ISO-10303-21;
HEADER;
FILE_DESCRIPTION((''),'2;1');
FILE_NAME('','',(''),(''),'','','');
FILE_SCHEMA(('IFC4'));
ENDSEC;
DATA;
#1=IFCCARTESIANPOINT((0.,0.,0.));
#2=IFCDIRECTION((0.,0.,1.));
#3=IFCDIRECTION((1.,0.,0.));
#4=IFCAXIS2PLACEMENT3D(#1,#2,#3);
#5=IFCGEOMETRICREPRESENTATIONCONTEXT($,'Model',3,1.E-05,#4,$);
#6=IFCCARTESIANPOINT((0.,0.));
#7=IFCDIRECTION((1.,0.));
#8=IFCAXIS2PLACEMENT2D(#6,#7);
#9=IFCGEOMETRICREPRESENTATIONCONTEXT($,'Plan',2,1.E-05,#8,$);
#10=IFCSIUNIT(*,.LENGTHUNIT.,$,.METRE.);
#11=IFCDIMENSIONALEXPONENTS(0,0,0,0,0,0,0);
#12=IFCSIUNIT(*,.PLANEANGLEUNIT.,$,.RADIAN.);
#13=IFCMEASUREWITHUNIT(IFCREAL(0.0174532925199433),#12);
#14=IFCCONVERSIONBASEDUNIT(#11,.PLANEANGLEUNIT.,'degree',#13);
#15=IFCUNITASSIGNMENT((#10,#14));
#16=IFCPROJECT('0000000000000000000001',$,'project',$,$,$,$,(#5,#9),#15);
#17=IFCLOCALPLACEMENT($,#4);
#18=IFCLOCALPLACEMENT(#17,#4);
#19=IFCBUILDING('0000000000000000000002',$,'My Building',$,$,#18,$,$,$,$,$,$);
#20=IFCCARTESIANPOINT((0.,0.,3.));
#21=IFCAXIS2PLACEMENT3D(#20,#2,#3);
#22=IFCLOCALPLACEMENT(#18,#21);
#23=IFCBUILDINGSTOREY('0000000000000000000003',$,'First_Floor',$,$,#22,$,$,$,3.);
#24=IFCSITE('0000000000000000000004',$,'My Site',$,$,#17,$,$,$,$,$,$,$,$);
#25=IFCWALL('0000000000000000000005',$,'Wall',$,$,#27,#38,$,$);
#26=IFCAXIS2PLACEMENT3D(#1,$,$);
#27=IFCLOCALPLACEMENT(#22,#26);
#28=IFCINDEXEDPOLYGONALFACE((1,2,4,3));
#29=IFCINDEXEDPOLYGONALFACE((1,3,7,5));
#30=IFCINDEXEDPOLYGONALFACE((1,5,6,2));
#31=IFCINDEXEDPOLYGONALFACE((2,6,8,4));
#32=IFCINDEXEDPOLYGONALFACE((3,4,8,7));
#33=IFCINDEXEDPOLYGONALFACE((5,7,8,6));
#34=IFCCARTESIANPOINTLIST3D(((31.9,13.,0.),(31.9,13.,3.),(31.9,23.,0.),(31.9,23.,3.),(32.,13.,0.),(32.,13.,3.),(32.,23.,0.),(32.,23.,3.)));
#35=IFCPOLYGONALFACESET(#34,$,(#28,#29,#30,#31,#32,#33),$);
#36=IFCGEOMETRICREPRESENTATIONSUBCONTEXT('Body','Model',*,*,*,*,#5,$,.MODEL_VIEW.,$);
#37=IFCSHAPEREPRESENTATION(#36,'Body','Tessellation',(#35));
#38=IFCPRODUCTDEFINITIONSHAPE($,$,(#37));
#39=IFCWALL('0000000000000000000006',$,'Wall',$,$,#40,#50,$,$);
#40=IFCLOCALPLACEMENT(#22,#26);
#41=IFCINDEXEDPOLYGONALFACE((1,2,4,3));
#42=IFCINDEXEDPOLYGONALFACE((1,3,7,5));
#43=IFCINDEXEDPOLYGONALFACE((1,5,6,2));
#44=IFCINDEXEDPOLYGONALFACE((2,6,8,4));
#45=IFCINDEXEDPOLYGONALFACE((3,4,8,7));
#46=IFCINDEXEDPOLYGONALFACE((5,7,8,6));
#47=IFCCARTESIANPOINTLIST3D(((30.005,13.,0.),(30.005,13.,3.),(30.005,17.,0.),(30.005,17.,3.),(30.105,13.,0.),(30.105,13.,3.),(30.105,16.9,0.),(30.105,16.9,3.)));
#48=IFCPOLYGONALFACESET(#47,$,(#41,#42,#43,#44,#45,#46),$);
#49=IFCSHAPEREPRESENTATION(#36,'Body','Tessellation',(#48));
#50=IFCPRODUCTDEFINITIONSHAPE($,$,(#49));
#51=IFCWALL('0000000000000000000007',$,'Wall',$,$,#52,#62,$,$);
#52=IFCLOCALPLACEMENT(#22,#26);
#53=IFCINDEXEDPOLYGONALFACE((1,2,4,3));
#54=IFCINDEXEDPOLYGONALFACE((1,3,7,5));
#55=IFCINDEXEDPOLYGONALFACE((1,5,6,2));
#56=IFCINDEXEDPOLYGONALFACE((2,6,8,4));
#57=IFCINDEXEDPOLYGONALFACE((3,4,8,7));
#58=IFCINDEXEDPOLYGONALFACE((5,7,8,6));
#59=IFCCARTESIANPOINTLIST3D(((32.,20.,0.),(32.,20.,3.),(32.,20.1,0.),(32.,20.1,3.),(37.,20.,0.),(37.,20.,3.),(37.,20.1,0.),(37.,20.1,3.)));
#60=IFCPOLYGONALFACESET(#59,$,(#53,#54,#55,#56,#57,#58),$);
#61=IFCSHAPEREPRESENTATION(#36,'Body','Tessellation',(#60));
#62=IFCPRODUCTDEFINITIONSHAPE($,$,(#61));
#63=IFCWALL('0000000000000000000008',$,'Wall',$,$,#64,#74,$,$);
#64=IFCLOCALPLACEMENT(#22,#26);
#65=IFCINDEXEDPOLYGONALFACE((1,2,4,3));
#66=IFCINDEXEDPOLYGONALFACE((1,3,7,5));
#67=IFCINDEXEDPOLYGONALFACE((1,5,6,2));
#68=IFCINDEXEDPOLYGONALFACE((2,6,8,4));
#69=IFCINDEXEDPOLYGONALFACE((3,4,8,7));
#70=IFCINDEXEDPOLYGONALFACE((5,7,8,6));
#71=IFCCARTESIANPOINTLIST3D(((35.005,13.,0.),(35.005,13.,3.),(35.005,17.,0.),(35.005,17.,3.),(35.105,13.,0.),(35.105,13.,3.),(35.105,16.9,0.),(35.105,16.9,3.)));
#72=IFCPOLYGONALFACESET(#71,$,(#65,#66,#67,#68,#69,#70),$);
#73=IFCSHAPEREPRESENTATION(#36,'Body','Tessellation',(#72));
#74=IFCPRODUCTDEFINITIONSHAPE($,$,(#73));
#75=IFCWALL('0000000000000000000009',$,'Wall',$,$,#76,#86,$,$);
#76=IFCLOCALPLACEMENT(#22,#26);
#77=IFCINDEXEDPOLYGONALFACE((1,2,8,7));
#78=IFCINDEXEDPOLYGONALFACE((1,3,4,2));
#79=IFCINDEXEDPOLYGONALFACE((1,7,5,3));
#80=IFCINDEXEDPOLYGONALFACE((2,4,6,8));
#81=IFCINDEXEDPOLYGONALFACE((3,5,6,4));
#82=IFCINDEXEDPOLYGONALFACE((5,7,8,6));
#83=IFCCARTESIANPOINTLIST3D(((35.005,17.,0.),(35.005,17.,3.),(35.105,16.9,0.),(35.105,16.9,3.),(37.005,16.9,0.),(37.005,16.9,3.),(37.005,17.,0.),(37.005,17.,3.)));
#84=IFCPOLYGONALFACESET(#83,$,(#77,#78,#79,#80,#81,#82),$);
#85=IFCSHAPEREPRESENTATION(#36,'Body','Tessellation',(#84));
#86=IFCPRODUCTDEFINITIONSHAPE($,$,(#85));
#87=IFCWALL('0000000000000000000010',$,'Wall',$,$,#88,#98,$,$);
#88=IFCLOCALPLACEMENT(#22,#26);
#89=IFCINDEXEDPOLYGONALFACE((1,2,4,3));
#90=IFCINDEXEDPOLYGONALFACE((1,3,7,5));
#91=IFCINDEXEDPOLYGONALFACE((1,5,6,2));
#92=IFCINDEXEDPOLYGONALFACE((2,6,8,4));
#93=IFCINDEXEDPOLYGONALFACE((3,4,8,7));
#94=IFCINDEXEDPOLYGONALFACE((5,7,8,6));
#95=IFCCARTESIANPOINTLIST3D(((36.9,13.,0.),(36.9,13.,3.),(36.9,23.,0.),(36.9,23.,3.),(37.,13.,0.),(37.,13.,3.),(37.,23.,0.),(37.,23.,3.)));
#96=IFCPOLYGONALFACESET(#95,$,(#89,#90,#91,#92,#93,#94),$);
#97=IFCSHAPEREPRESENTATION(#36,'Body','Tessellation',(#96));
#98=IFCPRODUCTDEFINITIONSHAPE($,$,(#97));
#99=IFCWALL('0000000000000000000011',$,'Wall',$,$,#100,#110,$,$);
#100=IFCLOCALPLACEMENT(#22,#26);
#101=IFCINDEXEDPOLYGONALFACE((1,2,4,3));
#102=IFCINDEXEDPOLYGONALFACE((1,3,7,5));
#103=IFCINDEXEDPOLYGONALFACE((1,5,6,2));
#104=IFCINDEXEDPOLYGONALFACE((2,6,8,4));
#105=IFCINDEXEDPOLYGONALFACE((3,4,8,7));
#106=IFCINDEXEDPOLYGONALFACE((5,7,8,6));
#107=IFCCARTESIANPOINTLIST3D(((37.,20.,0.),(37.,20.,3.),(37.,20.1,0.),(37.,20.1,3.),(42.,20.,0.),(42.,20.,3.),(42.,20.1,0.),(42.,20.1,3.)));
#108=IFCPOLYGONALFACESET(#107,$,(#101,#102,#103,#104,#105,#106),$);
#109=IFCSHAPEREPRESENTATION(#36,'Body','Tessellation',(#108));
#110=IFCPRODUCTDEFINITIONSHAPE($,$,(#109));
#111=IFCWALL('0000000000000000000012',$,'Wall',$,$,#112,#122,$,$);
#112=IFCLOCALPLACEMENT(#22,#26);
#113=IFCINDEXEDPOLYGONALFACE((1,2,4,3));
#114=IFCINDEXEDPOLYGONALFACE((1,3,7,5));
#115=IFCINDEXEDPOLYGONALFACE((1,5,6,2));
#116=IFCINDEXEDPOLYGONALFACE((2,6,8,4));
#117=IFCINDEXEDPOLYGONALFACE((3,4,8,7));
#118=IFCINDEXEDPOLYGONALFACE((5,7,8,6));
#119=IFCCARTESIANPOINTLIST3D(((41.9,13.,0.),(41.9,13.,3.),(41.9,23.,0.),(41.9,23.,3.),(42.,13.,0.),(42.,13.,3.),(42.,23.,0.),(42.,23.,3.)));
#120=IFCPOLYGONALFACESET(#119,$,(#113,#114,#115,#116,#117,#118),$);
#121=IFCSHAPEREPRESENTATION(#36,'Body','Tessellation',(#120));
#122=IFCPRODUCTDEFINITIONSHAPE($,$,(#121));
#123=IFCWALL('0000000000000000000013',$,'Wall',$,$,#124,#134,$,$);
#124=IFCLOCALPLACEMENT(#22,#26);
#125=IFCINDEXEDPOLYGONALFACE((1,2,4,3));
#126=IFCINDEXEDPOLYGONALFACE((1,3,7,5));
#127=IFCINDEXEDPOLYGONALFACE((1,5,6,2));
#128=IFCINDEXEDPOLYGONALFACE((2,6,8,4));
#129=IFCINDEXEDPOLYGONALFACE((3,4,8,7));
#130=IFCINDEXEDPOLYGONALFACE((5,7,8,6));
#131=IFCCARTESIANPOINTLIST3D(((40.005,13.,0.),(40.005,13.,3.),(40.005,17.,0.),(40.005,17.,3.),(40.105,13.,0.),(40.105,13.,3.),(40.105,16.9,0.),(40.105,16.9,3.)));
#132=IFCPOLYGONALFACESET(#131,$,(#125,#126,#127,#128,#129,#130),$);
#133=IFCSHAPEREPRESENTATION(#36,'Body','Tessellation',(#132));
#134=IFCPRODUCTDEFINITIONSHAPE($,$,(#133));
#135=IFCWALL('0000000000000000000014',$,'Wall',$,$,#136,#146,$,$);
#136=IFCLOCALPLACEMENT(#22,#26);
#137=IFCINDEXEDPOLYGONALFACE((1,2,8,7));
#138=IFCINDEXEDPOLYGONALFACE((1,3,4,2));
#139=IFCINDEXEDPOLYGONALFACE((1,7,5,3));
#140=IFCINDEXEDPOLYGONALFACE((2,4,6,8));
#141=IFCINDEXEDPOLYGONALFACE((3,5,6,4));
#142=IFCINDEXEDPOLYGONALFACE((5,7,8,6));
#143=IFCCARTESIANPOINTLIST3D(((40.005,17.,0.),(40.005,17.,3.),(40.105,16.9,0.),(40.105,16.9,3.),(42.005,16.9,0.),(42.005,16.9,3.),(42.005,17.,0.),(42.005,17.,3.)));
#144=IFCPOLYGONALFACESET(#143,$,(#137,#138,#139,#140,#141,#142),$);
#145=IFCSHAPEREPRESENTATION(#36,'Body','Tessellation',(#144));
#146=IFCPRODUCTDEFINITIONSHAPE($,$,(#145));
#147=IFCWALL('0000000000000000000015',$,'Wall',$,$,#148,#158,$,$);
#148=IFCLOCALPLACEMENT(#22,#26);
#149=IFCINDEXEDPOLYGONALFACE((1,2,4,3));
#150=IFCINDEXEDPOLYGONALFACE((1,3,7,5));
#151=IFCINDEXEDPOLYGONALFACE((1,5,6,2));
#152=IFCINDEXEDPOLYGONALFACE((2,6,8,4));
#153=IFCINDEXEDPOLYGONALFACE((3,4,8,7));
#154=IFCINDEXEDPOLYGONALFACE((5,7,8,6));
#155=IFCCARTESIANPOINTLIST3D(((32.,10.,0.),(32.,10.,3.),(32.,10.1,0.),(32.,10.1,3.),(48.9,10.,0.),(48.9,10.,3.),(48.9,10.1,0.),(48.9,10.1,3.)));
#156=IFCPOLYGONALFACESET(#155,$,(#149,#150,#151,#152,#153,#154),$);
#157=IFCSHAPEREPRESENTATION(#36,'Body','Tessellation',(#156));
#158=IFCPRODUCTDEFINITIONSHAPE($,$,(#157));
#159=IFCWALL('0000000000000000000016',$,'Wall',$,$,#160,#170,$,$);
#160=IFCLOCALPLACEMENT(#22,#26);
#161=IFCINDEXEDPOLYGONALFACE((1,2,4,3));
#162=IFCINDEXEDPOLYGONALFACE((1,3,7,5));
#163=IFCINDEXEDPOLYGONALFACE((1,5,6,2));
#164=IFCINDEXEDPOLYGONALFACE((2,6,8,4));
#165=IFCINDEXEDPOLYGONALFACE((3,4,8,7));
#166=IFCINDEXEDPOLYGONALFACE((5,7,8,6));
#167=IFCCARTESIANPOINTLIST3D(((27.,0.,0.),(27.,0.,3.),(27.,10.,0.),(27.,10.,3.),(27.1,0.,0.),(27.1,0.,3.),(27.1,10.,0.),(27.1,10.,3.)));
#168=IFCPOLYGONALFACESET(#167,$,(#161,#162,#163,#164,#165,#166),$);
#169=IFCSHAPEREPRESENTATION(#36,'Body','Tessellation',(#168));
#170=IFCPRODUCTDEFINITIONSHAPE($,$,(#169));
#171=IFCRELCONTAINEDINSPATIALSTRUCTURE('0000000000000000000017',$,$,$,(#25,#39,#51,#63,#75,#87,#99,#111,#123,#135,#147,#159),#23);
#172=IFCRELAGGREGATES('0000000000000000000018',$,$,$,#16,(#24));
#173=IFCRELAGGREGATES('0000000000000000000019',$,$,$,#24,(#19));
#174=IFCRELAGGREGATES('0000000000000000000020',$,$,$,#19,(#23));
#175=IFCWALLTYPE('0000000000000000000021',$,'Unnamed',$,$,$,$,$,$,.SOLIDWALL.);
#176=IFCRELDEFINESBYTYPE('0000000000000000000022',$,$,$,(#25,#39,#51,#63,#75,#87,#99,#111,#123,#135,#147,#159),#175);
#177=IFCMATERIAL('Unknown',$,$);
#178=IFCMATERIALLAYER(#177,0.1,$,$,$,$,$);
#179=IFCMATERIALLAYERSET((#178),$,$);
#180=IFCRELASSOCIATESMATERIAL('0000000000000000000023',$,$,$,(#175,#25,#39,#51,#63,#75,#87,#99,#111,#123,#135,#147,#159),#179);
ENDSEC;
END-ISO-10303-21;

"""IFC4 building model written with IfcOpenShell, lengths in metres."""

from ifc_helpers import new_model, entity, si_unit, converted_unit, frame, origin_with_axes, origin_2d_with_axis, place, context, subcontext, project, spatial, line, indexed_curve, outline, extrude, material, layer, layer_set, layer_usage, type_object, element, save


model = new_model("IFC4")

# Units and contexts
model_context = context("Model", 3, precision=1e-05, world=origin_with_axes())
plan_context = context("Plan", 2, precision=1e-05, world=origin_2d_with_axis())
body_context = subcontext(model_context, "Body", "Model", "MODEL_VIEW")
ifc_project = project(units=[si_unit("LENGTHUNIT", "METRE"), converted_unit("PLANEANGLEUNIT", "degree", entity("IfcReal", 0.0174532925199433), si_unit("PLANEANGLEUNIT", "RADIAN"), dimensions=[0, 0, 0, 0, 0, 0, 0])], contexts=[model_context, plan_context])

# Site, building, storey
site_placement = place(None, origin_with_axes())
site = spatial("IfcSite", under=ifc_project, at=site_placement, Name="My Site")
building_placement = place(site_placement, origin_with_axes())
building = spatial("IfcBuilding", under=site, at=building_placement, Name="My Building")
storey_placement = place(building_placement, frame((0.0, 0.0, 3.0), z_axis=(0.0, 0.0, 1.0), x_axis=(1.0, 0.0, 0.0)))
storey = spatial("IfcBuildingStorey", under=building, at=storey_placement, Name="First_Floor", Elevation=3.0)

# Shared definitions
ifc_material = material(Name="Unknown")

# Walls
ifc_layer_1 = layer(ifc_material, 0.1)
ifc_layer_set_1 = layer_set([ifc_layer_1])
wall_type = type_object("IfcWallType", Name="Unnamed", PredefinedType="SOLIDWALL", material=ifc_layer_set_1)
ifc_layer_usage_1 = layer_usage(ifc_layer_set_1, "AXIS2", "POSITIVE", 0.0)
wall_1_placement = place(storey_placement, frame((31.9, 23.0, 0.0), z_axis=(0.0, 0.0, 1.0), x_axis=(0.0, -1.0, 0.0)))
element("IfcWall", 1, at=wall_1_placement, inside=storey, type_object=wall_type, material=ifc_layer_usage_1, Name="Wall", context=body_context, shape_type="SweptSolid", body=[
    extrude(outline(indexed_curve([(0.0, 0.0), (0.0, 0.1), (10.0, 0.1), (10.0, 0.0)], segments=[line(1, 2, 3, 4, 1)])), origin_with_axes(), (0.0, 0.0, 1.0), 3.0),
])
ifc_layer_usage_2 = layer_usage(ifc_layer_set_1, "AXIS2", "POSITIVE", 0.0)
wall_2_placement = place(storey_placement, frame((30.005, 17.0, 0.0), z_axis=(0.0, 0.0, 1.0), x_axis=(0.0, -1.0, 0.0)))
element("IfcWall", 2, at=wall_2_placement, inside=storey, type_object=wall_type, material=ifc_layer_usage_2, Name="Wall", context=body_context, shape_type="SweptSolid", body=[
    extrude(outline(indexed_curve([(0.0, 0.0), (0.1, 0.1), (4.0, 0.1), (4.0, 0.0)], segments=[line(1, 2, 3, 4, 1)])), origin_with_axes(), (0.0, 0.0, 1.0), 3.0),
])
ifc_layer_usage_3 = layer_usage(ifc_layer_set_1, "AXIS2", "POSITIVE", 0.0)
wall_3_placement = place(storey_placement, frame((32.0, 20.0, 0.0), z_axis=(0.0, 0.0, 1.0), x_axis=(1.0, 0.0, 0.0)))
element("IfcWall", 3, at=wall_3_placement, inside=storey, type_object=wall_type, material=ifc_layer_usage_3, Name="Wall", context=body_context, shape_type="SweptSolid", body=[
    extrude(outline(indexed_curve([(0.0, 0.0), (0.0, 0.1), (5.0, 0.1), (5.0, 0.0)], segments=[line(1, 2, 3, 4, 1)])), origin_with_axes(), (0.0, 0.0, 1.0), 3.0),
])
ifc_layer_usage_4 = layer_usage(ifc_layer_set_1, "AXIS2", "POSITIVE", 0.0)
wall_4_placement = place(storey_placement, frame((35.005, 17.0, 0.0), z_axis=(0.0, 0.0, 1.0), x_axis=(0.0, -1.0, 0.0)))
element("IfcWall", 4, at=wall_4_placement, inside=storey, type_object=wall_type, material=ifc_layer_usage_4, Name="Wall", context=body_context, shape_type="SweptSolid", body=[
    extrude(outline(indexed_curve([(0.0, 0.0), (0.1, 0.1), (4.0, 0.1), (4.0, 0.0)], segments=[line(1, 2, 3, 4, 1)])), origin_with_axes(), (0.0, 0.0, 1.0), 3.0),
])
ifc_layer_usage_5 = layer_usage(ifc_layer_set_1, "AXIS2", "POSITIVE", 0.0)
wall_5_placement = place(storey_placement, frame((37.005, 17.0, 0.0), z_axis=(0.0, 0.0, 1.0), x_axis=(-1.0, 0.0, 0.0)))
element("IfcWall", 5, at=wall_5_placement, inside=storey, type_object=wall_type, material=ifc_layer_usage_5, Name="Wall", context=body_context, shape_type="SweptSolid", body=[
    extrude(outline(indexed_curve([(0.0, 0.0), (0.0, 0.1), (1.9, 0.1), (2.0, 0.0)], segments=[line(1, 2, 3, 4, 1)])), origin_with_axes(), (0.0, 0.0, 1.0), 3.0),
])
ifc_layer_usage_6 = layer_usage(ifc_layer_set_1, "AXIS2", "POSITIVE", 0.0)
wall_6_placement = place(storey_placement, frame((36.9, 23.0, 0.0), z_axis=(0.0, 0.0, 1.0), x_axis=(0.0, -1.0, 0.0)))
element("IfcWall", 6, at=wall_6_placement, inside=storey, type_object=wall_type, material=ifc_layer_usage_6, Name="Wall", context=body_context, shape_type="SweptSolid", body=[
    extrude(outline(indexed_curve([(0.0, 0.0), (0.0, 0.1), (10.0, 0.1), (10.0, 0.0)], segments=[line(1, 2, 3, 4, 1)])), origin_with_axes(), (0.0, 0.0, 1.0), 3.0),
])
ifc_layer_usage_7 = layer_usage(ifc_layer_set_1, "AXIS2", "POSITIVE", 0.0)
wall_7_placement = place(storey_placement, frame((37.0, 20.0, 0.0), z_axis=(0.0, 0.0, 1.0), x_axis=(1.0, 0.0, 0.0)))
element("IfcWall", 7, at=wall_7_placement, inside=storey, type_object=wall_type, material=ifc_layer_usage_7, Name="Wall", context=body_context, shape_type="SweptSolid", body=[
    extrude(outline(indexed_curve([(0.0, 0.0), (0.0, 0.1), (5.0, 0.1), (5.0, 0.0)], segments=[line(1, 2, 3, 4, 1)])), origin_with_axes(), (0.0, 0.0, 1.0), 3.0),
])
ifc_layer_usage_8 = layer_usage(ifc_layer_set_1, "AXIS2", "POSITIVE", 0.0)
wall_8_placement = place(storey_placement, frame((41.9, 23.0, 0.0), z_axis=(0.0, 0.0, 1.0), x_axis=(0.0, -1.0, 0.0)))
element("IfcWall", 8, at=wall_8_placement, inside=storey, type_object=wall_type, material=ifc_layer_usage_8, Name="Wall", context=body_context, shape_type="SweptSolid", body=[
    extrude(outline(indexed_curve([(0.0, 0.0), (0.0, 0.1), (10.0, 0.1), (10.0, 0.0)], segments=[line(1, 2, 3, 4, 1)])), origin_with_axes(), (0.0, 0.0, 1.0), 3.0),
])
ifc_layer_usage_9 = layer_usage(ifc_layer_set_1, "AXIS2", "POSITIVE", 0.0)
wall_9_placement = place(storey_placement, frame((40.005, 17.0, 0.0), z_axis=(0.0, 0.0, 1.0), x_axis=(0.0, -1.0, 0.0)))
element("IfcWall", 9, at=wall_9_placement, inside=storey, type_object=wall_type, material=ifc_layer_usage_9, Name="Wall", context=body_context, shape_type="SweptSolid", body=[
    extrude(outline(indexed_curve([(0.0, 0.0), (0.1, 0.1), (4.0, 0.1), (4.0, 0.0)], segments=[line(1, 2, 3, 4, 1)])), origin_with_axes(), (0.0, 0.0, 1.0), 3.0),
])
ifc_layer_usage_10 = layer_usage(ifc_layer_set_1, "AXIS2", "POSITIVE", 0.0)
wall_10_placement = place(storey_placement, frame((42.005, 17.0, 0.0), z_axis=(0.0, 0.0, 1.0), x_axis=(-1.0, 0.0, 0.0)))
element("IfcWall", 10, at=wall_10_placement, inside=storey, type_object=wall_type, material=ifc_layer_usage_10, Name="Wall", context=body_context, shape_type="SweptSolid", body=[
    extrude(outline(indexed_curve([(0.0, 0.0), (0.0, 0.1), (1.9, 0.1), (2.0, 0.0)], segments=[line(1, 2, 3, 4, 1)])), origin_with_axes(), (0.0, 0.0, 1.0), 3.0),
])
ifc_layer_usage_11 = layer_usage(ifc_layer_set_1, "AXIS2", "POSITIVE", 0.0)
wall_11_placement = place(storey_placement, frame((32.0, 10.0, 0.0), z_axis=(0.0, 0.0, 1.0), x_axis=(1.0, 0.0, 0.0)))
element("IfcWall", 11, at=wall_11_placement, inside=storey, type_object=wall_type, material=ifc_layer_usage_11, Name="Wall", context=body_context, shape_type="SweptSolid", body=[
    extrude(outline(indexed_curve([(0.0, 0.0), (0.0, 0.1), (16.9, 0.1), (16.9, 0.0)], segments=[line(1, 2, 3, 4, 1)])), origin_with_axes(), (0.0, 0.0, 1.0), 3.0),
])
ifc_layer_usage_12 = layer_usage(ifc_layer_set_1, "AXIS2", "POSITIVE", 0.0)
wall_12_placement = place(storey_placement, frame((27.0, 10.0, 0.0), z_axis=(0.0, 0.0, 1.0), x_axis=(0.0, -1.0, 0.0)))
element("IfcWall", 12, at=wall_12_placement, inside=storey, type_object=wall_type, material=ifc_layer_usage_12, Name="Wall", context=body_context, shape_type="SweptSolid", body=[
    extrude(outline(indexed_curve([(0.0, 0.0), (0.0, 0.1), (10.0, 0.1), (10.0, 0.0)], segments=[line(1, 2, 3, 4, 1)])), origin_with_axes(), (0.0, 0.0, 1.0), 3.0),
])

save(model, "model.ifc")
